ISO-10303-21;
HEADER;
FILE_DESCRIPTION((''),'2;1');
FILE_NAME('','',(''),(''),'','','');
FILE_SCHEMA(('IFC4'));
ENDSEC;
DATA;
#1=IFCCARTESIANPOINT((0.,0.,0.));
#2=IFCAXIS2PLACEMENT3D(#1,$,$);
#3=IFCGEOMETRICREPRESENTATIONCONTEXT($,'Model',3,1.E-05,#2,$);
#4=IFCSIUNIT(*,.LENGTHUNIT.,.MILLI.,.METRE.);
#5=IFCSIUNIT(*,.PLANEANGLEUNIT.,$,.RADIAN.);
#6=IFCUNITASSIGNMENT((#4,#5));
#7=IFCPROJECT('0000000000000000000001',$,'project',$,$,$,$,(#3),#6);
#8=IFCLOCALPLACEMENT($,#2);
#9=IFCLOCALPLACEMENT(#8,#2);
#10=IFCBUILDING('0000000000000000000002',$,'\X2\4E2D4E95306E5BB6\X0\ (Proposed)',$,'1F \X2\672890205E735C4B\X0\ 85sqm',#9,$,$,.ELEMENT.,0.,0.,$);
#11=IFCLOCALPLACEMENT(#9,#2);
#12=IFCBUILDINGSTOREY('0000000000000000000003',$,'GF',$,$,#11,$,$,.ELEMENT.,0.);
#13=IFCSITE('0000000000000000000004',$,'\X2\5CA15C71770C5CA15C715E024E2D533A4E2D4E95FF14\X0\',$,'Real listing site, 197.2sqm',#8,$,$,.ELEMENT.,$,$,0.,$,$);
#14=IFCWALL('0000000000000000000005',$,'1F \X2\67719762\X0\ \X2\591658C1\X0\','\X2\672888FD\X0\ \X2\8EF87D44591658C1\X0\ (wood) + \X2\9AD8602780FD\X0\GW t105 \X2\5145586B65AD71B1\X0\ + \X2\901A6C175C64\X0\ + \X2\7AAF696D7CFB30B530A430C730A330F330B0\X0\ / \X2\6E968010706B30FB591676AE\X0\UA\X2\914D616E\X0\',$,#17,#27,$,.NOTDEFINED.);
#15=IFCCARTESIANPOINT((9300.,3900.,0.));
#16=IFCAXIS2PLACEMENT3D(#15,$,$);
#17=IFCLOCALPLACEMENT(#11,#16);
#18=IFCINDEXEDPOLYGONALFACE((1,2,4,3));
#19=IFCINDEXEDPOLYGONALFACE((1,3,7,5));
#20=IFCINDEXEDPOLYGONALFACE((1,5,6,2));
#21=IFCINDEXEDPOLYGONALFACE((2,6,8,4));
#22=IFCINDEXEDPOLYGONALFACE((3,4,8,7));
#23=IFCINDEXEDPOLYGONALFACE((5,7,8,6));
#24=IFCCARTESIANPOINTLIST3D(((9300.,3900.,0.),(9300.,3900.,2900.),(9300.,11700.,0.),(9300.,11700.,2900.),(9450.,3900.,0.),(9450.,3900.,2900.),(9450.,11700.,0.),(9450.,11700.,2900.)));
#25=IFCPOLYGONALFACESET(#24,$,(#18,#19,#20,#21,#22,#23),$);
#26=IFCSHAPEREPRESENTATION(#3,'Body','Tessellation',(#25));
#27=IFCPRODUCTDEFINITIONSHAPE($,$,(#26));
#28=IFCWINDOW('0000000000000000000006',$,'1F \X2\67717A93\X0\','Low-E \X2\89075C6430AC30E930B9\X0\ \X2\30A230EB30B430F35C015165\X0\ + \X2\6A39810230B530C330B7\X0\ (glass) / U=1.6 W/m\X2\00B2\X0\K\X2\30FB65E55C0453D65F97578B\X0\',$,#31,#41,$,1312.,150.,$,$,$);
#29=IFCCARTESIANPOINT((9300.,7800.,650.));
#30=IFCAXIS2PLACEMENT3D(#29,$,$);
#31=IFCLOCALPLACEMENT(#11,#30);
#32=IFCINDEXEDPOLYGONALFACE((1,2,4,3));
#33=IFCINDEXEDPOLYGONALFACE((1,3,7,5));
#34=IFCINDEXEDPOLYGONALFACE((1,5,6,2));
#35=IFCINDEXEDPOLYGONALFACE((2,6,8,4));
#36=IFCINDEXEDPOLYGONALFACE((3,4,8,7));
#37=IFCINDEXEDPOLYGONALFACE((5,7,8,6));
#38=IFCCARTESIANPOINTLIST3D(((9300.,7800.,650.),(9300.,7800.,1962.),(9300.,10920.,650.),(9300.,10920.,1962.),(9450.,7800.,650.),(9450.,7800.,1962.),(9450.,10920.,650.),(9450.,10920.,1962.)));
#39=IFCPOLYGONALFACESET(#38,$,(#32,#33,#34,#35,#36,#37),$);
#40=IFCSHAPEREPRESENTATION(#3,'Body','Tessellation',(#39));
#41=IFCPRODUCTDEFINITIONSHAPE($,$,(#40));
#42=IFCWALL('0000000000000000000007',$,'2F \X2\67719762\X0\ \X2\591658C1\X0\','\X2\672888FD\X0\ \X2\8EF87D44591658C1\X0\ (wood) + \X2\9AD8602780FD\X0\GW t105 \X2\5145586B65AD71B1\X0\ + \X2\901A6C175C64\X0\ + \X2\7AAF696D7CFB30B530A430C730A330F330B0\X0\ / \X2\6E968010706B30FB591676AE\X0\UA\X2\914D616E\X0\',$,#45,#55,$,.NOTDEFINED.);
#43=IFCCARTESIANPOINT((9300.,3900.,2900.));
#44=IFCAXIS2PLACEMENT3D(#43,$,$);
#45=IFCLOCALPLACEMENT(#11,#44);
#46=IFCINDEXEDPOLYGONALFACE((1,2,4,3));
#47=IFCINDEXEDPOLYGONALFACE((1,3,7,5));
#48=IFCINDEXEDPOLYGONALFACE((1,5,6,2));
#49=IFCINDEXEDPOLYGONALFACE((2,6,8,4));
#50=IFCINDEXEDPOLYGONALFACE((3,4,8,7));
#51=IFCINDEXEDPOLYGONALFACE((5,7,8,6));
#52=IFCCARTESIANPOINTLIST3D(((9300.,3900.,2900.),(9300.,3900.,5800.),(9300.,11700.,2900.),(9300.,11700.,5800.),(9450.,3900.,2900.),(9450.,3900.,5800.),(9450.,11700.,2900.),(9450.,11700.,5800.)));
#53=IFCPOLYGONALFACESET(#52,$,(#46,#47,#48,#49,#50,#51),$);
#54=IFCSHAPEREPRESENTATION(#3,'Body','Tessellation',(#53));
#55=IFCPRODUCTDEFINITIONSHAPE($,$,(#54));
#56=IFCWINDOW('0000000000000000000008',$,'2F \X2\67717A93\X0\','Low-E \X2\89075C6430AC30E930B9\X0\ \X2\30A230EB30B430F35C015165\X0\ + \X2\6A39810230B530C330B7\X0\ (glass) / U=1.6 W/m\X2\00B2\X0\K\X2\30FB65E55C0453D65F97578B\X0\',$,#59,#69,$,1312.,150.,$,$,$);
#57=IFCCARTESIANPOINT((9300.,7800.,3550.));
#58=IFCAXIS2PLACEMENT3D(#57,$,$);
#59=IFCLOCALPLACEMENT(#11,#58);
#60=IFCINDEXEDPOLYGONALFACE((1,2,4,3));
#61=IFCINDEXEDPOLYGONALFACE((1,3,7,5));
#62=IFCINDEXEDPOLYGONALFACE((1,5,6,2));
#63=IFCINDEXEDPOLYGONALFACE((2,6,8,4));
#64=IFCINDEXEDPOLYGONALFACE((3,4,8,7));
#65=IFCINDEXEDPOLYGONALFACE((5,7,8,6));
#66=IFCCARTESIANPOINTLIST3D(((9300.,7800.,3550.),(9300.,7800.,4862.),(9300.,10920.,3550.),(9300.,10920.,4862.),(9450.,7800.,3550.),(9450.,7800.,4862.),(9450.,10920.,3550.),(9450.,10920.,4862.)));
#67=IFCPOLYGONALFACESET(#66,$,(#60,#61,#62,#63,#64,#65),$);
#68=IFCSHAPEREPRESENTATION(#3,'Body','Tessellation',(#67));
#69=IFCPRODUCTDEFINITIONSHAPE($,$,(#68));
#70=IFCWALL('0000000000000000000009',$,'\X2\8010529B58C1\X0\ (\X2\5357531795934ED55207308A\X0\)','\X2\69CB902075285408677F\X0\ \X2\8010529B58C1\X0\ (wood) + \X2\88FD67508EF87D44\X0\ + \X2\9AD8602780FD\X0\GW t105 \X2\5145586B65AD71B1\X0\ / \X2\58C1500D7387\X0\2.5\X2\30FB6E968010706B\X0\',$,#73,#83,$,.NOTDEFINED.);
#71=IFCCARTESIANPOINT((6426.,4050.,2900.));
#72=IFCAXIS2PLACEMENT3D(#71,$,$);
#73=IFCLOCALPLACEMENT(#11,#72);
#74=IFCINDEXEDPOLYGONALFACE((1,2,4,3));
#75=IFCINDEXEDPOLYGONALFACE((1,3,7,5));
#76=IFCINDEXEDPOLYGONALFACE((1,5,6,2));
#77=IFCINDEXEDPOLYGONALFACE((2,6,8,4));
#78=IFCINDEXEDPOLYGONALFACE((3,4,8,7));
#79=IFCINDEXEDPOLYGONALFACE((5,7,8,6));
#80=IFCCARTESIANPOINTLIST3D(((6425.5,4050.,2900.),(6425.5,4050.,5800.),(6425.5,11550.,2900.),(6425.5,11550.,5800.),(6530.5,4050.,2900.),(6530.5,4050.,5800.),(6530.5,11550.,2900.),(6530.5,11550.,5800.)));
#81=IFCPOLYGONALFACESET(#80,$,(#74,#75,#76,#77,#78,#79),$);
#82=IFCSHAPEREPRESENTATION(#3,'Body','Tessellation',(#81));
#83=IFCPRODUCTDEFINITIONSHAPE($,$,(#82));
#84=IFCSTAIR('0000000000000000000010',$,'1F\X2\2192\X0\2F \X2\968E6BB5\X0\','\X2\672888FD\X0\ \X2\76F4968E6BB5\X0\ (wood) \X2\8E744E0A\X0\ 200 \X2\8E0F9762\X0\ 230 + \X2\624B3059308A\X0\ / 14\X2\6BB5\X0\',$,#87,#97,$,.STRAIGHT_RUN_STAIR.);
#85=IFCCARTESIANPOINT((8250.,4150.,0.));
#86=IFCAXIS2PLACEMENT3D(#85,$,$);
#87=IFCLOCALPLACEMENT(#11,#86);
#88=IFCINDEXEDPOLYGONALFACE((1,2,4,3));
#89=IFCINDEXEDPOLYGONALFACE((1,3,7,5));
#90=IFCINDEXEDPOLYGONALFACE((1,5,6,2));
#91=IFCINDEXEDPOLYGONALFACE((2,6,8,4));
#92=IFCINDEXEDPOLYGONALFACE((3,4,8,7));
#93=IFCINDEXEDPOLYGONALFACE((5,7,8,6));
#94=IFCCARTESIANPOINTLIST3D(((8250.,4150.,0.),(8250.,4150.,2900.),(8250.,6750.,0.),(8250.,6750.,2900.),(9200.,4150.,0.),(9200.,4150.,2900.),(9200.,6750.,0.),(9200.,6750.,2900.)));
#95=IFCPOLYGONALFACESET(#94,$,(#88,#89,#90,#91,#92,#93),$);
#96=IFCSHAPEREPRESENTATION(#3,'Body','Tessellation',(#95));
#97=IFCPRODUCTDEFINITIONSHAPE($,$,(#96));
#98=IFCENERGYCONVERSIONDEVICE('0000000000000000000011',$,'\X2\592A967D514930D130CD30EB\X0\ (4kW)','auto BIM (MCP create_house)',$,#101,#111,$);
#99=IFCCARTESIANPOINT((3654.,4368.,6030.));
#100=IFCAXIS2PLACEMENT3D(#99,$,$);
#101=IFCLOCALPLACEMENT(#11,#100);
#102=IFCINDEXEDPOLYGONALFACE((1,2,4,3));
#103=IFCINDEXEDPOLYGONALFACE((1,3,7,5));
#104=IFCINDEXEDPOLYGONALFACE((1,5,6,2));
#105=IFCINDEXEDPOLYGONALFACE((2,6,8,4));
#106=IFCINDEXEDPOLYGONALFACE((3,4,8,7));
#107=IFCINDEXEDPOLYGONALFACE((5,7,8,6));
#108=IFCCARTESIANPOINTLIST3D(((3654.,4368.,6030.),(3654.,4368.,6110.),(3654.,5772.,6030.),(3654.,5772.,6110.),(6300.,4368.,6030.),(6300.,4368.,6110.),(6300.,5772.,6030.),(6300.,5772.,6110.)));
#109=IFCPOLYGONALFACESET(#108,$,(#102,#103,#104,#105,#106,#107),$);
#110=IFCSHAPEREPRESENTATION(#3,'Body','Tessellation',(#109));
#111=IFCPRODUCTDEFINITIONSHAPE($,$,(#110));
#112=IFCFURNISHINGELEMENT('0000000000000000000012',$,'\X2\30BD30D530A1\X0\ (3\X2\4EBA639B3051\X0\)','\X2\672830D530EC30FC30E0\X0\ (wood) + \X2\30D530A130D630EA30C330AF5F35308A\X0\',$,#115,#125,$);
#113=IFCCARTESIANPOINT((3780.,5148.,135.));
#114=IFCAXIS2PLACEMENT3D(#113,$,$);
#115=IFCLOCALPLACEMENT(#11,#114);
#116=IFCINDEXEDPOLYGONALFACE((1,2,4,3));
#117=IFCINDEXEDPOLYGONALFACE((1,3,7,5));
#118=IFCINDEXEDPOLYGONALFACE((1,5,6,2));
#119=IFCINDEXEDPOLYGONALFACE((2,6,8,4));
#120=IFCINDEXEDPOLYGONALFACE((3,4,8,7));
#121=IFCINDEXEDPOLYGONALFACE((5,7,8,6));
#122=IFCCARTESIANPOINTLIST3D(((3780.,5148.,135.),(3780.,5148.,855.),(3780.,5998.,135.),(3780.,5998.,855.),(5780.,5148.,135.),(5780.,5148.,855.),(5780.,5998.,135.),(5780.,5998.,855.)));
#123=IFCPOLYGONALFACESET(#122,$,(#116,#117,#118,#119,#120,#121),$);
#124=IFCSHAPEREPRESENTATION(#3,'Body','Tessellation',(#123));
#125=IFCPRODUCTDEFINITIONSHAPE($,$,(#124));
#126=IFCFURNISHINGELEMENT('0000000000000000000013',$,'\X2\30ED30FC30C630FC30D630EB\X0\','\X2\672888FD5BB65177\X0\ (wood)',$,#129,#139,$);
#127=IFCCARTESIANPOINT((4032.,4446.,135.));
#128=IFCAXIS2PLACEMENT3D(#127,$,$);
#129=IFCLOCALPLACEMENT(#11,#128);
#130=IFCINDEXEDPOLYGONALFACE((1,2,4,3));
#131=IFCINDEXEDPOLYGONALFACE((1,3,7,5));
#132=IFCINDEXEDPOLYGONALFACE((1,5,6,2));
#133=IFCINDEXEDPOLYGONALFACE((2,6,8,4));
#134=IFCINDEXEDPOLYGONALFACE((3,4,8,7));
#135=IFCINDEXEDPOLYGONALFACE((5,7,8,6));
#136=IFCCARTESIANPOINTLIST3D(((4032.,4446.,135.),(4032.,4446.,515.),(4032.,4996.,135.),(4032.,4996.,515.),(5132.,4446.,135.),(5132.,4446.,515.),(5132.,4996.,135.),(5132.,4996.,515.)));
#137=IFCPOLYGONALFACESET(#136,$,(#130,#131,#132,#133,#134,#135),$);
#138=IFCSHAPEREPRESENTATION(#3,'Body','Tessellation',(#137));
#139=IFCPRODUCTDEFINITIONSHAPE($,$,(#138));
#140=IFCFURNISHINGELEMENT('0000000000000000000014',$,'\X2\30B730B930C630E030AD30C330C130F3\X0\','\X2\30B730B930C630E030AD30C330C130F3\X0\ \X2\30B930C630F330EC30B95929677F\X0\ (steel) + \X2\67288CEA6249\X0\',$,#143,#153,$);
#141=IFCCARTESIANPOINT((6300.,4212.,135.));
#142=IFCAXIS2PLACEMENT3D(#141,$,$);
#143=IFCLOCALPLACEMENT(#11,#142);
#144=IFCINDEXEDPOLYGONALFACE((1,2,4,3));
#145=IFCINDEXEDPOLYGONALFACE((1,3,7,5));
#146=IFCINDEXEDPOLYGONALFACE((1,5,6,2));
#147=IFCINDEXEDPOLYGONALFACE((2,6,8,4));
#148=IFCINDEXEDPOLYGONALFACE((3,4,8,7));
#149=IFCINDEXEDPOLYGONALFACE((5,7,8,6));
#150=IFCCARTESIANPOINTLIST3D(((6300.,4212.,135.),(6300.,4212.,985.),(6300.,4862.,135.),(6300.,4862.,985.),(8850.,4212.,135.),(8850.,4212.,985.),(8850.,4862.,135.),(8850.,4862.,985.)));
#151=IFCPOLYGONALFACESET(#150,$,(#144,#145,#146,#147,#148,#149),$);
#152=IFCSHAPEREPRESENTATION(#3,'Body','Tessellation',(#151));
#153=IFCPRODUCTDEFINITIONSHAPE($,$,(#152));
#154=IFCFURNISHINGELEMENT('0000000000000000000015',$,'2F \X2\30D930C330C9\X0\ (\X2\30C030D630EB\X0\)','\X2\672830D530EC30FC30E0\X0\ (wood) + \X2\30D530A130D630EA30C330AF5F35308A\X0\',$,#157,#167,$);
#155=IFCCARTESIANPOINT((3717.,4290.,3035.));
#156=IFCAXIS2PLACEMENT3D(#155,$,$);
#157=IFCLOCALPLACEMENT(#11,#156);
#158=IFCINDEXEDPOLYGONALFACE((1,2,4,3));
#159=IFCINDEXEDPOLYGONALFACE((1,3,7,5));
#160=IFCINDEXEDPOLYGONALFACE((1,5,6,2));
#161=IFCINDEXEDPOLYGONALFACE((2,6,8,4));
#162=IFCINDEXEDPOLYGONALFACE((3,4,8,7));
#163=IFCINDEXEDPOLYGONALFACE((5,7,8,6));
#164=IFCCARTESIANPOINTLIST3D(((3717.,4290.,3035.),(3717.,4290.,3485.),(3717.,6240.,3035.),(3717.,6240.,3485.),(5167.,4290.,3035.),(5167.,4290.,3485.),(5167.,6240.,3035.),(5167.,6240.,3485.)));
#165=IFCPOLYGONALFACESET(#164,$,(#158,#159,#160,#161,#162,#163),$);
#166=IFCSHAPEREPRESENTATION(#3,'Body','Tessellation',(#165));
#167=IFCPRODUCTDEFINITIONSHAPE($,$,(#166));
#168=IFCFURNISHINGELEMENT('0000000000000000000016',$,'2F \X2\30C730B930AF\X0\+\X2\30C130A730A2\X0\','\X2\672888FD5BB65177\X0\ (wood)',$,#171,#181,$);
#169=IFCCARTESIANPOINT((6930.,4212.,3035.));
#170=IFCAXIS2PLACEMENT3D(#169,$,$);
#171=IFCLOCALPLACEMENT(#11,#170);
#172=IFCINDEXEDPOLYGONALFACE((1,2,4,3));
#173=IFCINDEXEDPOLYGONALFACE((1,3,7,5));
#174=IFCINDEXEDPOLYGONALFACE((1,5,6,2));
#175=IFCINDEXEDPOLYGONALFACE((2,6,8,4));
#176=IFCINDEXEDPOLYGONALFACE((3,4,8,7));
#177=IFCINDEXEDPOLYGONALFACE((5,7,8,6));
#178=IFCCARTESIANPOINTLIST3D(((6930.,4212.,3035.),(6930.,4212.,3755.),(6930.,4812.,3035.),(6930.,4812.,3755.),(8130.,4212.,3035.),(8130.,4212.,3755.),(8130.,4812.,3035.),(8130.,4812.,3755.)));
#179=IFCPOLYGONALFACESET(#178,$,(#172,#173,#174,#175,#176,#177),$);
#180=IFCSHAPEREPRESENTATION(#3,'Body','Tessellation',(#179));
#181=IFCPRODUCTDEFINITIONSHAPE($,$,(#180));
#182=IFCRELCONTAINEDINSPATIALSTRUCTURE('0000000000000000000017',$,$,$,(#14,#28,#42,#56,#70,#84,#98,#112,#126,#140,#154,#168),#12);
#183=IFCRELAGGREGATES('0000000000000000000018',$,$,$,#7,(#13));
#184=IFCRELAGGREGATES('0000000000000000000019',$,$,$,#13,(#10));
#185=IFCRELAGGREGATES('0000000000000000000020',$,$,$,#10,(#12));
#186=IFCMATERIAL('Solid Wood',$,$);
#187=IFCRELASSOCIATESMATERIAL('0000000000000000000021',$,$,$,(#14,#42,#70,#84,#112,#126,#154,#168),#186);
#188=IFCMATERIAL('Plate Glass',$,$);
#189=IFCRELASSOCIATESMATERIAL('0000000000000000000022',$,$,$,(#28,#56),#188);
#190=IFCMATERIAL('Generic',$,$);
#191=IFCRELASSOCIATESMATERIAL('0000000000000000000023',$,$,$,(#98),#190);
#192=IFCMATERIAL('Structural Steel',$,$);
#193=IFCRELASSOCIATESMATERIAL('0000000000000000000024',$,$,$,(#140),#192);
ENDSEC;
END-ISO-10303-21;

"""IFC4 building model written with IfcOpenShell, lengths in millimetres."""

from ifc_helpers import new_model, si_unit, frame, frame_2d, origin, place, context, project, spatial, rectangle, extrude, material, element, fill, save


model = new_model("IFC4")

# Units and contexts
model_context = context("Model", 3, precision=1e-05, world=origin())
ifc_project = project(units=[si_unit("LENGTHUNIT", "METRE", prefix="MILLI"), si_unit("PLANEANGLEUNIT", "RADIAN")], contexts=[model_context])

# Site, building, storey
site_placement = place(None, origin())
site = spatial("IfcSite", under=ifc_project, at=site_placement, Name="岡山県岡山市中区中井４", ObjectType="Real listing site, 197.2sqm", CompositionType="ELEMENT", RefElevation=0.0)
building_placement = place(site_placement, origin())
building = spatial("IfcBuilding", under=site, at=building_placement, Name="中井の家 (Proposed)", ObjectType="1F 木造平屋 85sqm", CompositionType="ELEMENT", ElevationOfRefHeight=0.0, ElevationOfTerrain=0.0)
storey_placement = place(building_placement, origin())
storey = spatial("IfcBuildingStorey", under=building, at=storey_placement, Name="GF", CompositionType="ELEMENT", Elevation=0.0)

# Wall, opening, window
ifc_material_1 = material(Name="Solid Wood")
wall_1_placement = place(storey_placement, frame((9300.0, 3900.0, 0.0)))
wall_1 = element("IfcWall", 1, at=wall_1_placement, inside=storey, material=ifc_material_1, Name="1F 東面 外壁", Description="木製 軸組外壁 (wood) + 高性能GW t105 充填断熱 + 通気層 + 窯業系サイディング / 準耐火・外皮UA配慮", PredefinedType="NOTDEFINED", context=model_context, shape_type="SweptSolid", body=[
    extrude(rectangle(XDim=150.0, YDim=7800.0, at=frame_2d((75.0, 3900.0))), frame((9300.0, 3900.0, 0.0)), (0.0, 0.0, 1.0), 2900.0),
])
opening_1_placement = place(storey_placement, frame((9300.0, 7800.0, 650.0)))
opening_1 = element("IfcOpeningElement", 2, at=opening_1_placement, cuts=wall_1, PredefinedType="NOTDEFINED", context=model_context, shape_type="SweptSolid", body=[
    extrude(rectangle(XDim=150.0, YDim=3120.0, at=frame_2d((75.0, 1560.0))), frame((9300.0, 7800.0, 650.0)), (0.0, 0.0, 1.0), 1312.0),
])
ifc_material_2 = material(Name="Plate Glass")
window_1_placement = place(storey_placement, frame((9300.0, 7800.0, 650.0)))
window_1 = element("IfcWindow", 3, at=window_1_placement, inside=storey, material=ifc_material_2, Name="1F 東窓", Description="Low-E 複層ガラス アルゴン封入 + 樹脂サッシ (glass) / U=1.6 W/m²K・日射取得型", OverallHeight=1312.0, OverallWidth=150.0, context=model_context, shape_type="SweptSolid", body=[
    extrude(rectangle(XDim=150.0, YDim=3120.0, at=frame_2d((75.0, 1560.0))), frame((9300.0, 7800.0, 650.0)), (0.0, 0.0, 1.0), 1312.0),
])
fill(opening_1, window_1)

# Wall, opening, window
wall_2_placement = place(storey_placement, frame((9300.0, 3900.0, 2900.0)))
wall_2 = element("IfcWall", 4, at=wall_2_placement, inside=storey, material=ifc_material_1, Name="2F 東面 外壁", Description="木製 軸組外壁 (wood) + 高性能GW t105 充填断熱 + 通気層 + 窯業系サイディング / 準耐火・外皮UA配慮", PredefinedType="NOTDEFINED", context=model_context, shape_type="SweptSolid", body=[
    extrude(rectangle(XDim=150.0, YDim=7800.0, at=frame_2d((75.0, 3900.0))), frame((9300.0, 3900.0, 2900.0)), (0.0, 0.0, 1.0), 2900.0),
])
opening_2_placement = place(storey_placement, frame((9300.0, 7800.0, 3550.0)))
opening_2 = element("IfcOpeningElement", 5, at=opening_2_placement, cuts=wall_2, PredefinedType="NOTDEFINED", context=model_context, shape_type="SweptSolid", body=[
    extrude(rectangle(XDim=150.0, YDim=3120.0, at=frame_2d((75.0, 1560.0))), frame((9300.0, 7800.0, 3550.0)), (0.0, 0.0, 1.0), 1312.0),
])
window_2_placement = place(storey_placement, frame((9300.0, 7800.0, 3550.0)))
window_2 = element("IfcWindow", 6, at=window_2_placement, inside=storey, material=ifc_material_2, Name="2F 東窓", Description="Low-E 複層ガラス アルゴン封入 + 樹脂サッシ (glass) / U=1.6 W/m²K・日射取得型", OverallHeight=1312.0, OverallWidth=150.0, context=model_context, shape_type="SweptSolid", body=[
    extrude(rectangle(XDim=150.0, YDim=3120.0, at=frame_2d((75.0, 1560.0))), frame((9300.0, 7800.0, 3550.0)), (0.0, 0.0, 1.0), 1312.0),
])
fill(opening_2, window_2)

# Wall
wall_3_placement = place(storey_placement, frame((6426.0, 4050.0, 2900.0)))
element("IfcWall", 7, at=wall_3_placement, inside=storey, material=ifc_material_1, Name="耐力壁 (南北間仕切り)", Description="構造用合板 耐力壁 (wood) + 製材軸組 + 高性能GW t105 充填断熱 / 壁倍率2.5・準耐火", PredefinedType="NOTDEFINED", context=model_context, shape_type="SweptSolid", body=[
    extrude(rectangle(XDim=105.0, YDim=7500.0, at=frame_2d((52.0, 3750.0))), frame((6426.0, 4050.0, 2900.0)), (0.0, 0.0, 1.0), 2900.0),
])

# Stair
stair_placement = place(storey_placement, frame((8250.0, 4150.0, 0.0)))
element("IfcStair", 8, at=stair_placement, inside=storey, material=ifc_material_1, Name="1F→2F 階段", Description="木製 直階段 (wood) 蹴上 200 踏面 230 + 手すり / 14段", PredefinedType="STRAIGHT_RUN_STAIR", context=model_context, shape_type="SweptSolid", body=[
    extrude(rectangle(XDim=950.0, YDim=2600.0, at=frame_2d((475.0, 1300.0))), frame((8250.0, 4150.0, 0.0)), (0.0, 0.0, 1.0), 2900.0),
])

# Energy conversion device
ifc_material_3 = material(Name="Generic")
energy_conversion_device_placement = place(storey_placement, frame((3654.0, 4368.0, 6030.0)))
element("IfcEnergyConversionDevice", 9, at=energy_conversion_device_placement, inside=storey, material=ifc_material_3, Name="太陽光パネル (4kW)", Description="auto BIM (MCP create_house)", context=model_context, shape_type="SweptSolid", body=[
    extrude(rectangle(XDim=2646.0, YDim=1404.0, at=frame_2d((1323.0, 702.0))), frame((3654.0, 4368.0, 6030.0)), (0.0, 0.0, 1.0), 80.0),
])

# Furnishing elements
furnishing_1_placement = place(storey_placement, frame((3780.0, 5148.0, 135.0)))
element("IfcFurnishingElement", 10, at=furnishing_1_placement, inside=storey, material=ifc_material_1, Name="ソファ (3人掛け)", Description="木フレーム (wood) + ファブリック張り", context=model_context, shape_type="SweptSolid", body=[
    extrude(rectangle(XDim=2000.0, YDim=850.0, at=frame_2d((1000.0, 425.0))), frame((3780.0, 5148.0, 135.0)), (0.0, 0.0, 1.0), 720.0),
])
furnishing_2_placement = place(storey_placement, frame((4032.0, 4446.0, 135.0)))
element("IfcFurnishingElement", 11, at=furnishing_2_placement, inside=storey, material=ifc_material_1, Name="ローテーブル", Description="木製家具 (wood)", context=model_context, shape_type="SweptSolid", body=[
    extrude(rectangle(XDim=1100.0, YDim=550.0, at=frame_2d((550.0, 275.0))), frame((4032.0, 4446.0, 135.0)), (0.0, 0.0, 1.0), 380.0),
])
ifc_material_4 = material(Name="Structural Steel")
furnishing_3_placement = place(storey_placement, frame((6300.0, 4212.0, 135.0)))
element("IfcFurnishingElement", 12, at=furnishing_3_placement, inside=storey, material=ifc_material_4, Name="システムキッチン", Description="システムキッチン ステンレス天板 (steel) + 木質扉", context=model_context, shape_type="SweptSolid", body=[
    extrude(rectangle(XDim=2550.0, YDim=650.0, at=frame_2d((1275.0, 325.0))), frame((6300.0, 4212.0, 135.0)), (0.0, 0.0, 1.0), 850.0),
])
furnishing_4_placement = place(storey_placement, frame((3717.0, 4290.0, 3035.0)))
element("IfcFurnishingElement", 13, at=furnishing_4_placement, inside=storey, material=ifc_material_1, Name="2F ベッド (ダブル)", Description="木フレーム (wood) + ファブリック張り", context=model_context, shape_type="SweptSolid", body=[
    extrude(rectangle(XDim=1450.0, YDim=1950.0, at=frame_2d((725.0, 975.0))), frame((3717.0, 4290.0, 3035.0)), (0.0, 0.0, 1.0), 450.0),
])
furnishing_5_placement = place(storey_placement, frame((6930.0, 4212.0, 3035.0)))
element("IfcFurnishingElement", 14, at=furnishing_5_placement, inside=storey, material=ifc_material_1, Name="2F デスク+チェア", Description="木製家具 (wood)", context=model_context, shape_type="SweptSolid", body=[
    extrude(rectangle(XDim=1200.0, YDim=600.0, at=frame_2d((600.0, 300.0))), frame((6930.0, 4212.0, 3035.0)), (0.0, 0.0, 1.0), 720.0),
])

save(model, "model.ifc")
